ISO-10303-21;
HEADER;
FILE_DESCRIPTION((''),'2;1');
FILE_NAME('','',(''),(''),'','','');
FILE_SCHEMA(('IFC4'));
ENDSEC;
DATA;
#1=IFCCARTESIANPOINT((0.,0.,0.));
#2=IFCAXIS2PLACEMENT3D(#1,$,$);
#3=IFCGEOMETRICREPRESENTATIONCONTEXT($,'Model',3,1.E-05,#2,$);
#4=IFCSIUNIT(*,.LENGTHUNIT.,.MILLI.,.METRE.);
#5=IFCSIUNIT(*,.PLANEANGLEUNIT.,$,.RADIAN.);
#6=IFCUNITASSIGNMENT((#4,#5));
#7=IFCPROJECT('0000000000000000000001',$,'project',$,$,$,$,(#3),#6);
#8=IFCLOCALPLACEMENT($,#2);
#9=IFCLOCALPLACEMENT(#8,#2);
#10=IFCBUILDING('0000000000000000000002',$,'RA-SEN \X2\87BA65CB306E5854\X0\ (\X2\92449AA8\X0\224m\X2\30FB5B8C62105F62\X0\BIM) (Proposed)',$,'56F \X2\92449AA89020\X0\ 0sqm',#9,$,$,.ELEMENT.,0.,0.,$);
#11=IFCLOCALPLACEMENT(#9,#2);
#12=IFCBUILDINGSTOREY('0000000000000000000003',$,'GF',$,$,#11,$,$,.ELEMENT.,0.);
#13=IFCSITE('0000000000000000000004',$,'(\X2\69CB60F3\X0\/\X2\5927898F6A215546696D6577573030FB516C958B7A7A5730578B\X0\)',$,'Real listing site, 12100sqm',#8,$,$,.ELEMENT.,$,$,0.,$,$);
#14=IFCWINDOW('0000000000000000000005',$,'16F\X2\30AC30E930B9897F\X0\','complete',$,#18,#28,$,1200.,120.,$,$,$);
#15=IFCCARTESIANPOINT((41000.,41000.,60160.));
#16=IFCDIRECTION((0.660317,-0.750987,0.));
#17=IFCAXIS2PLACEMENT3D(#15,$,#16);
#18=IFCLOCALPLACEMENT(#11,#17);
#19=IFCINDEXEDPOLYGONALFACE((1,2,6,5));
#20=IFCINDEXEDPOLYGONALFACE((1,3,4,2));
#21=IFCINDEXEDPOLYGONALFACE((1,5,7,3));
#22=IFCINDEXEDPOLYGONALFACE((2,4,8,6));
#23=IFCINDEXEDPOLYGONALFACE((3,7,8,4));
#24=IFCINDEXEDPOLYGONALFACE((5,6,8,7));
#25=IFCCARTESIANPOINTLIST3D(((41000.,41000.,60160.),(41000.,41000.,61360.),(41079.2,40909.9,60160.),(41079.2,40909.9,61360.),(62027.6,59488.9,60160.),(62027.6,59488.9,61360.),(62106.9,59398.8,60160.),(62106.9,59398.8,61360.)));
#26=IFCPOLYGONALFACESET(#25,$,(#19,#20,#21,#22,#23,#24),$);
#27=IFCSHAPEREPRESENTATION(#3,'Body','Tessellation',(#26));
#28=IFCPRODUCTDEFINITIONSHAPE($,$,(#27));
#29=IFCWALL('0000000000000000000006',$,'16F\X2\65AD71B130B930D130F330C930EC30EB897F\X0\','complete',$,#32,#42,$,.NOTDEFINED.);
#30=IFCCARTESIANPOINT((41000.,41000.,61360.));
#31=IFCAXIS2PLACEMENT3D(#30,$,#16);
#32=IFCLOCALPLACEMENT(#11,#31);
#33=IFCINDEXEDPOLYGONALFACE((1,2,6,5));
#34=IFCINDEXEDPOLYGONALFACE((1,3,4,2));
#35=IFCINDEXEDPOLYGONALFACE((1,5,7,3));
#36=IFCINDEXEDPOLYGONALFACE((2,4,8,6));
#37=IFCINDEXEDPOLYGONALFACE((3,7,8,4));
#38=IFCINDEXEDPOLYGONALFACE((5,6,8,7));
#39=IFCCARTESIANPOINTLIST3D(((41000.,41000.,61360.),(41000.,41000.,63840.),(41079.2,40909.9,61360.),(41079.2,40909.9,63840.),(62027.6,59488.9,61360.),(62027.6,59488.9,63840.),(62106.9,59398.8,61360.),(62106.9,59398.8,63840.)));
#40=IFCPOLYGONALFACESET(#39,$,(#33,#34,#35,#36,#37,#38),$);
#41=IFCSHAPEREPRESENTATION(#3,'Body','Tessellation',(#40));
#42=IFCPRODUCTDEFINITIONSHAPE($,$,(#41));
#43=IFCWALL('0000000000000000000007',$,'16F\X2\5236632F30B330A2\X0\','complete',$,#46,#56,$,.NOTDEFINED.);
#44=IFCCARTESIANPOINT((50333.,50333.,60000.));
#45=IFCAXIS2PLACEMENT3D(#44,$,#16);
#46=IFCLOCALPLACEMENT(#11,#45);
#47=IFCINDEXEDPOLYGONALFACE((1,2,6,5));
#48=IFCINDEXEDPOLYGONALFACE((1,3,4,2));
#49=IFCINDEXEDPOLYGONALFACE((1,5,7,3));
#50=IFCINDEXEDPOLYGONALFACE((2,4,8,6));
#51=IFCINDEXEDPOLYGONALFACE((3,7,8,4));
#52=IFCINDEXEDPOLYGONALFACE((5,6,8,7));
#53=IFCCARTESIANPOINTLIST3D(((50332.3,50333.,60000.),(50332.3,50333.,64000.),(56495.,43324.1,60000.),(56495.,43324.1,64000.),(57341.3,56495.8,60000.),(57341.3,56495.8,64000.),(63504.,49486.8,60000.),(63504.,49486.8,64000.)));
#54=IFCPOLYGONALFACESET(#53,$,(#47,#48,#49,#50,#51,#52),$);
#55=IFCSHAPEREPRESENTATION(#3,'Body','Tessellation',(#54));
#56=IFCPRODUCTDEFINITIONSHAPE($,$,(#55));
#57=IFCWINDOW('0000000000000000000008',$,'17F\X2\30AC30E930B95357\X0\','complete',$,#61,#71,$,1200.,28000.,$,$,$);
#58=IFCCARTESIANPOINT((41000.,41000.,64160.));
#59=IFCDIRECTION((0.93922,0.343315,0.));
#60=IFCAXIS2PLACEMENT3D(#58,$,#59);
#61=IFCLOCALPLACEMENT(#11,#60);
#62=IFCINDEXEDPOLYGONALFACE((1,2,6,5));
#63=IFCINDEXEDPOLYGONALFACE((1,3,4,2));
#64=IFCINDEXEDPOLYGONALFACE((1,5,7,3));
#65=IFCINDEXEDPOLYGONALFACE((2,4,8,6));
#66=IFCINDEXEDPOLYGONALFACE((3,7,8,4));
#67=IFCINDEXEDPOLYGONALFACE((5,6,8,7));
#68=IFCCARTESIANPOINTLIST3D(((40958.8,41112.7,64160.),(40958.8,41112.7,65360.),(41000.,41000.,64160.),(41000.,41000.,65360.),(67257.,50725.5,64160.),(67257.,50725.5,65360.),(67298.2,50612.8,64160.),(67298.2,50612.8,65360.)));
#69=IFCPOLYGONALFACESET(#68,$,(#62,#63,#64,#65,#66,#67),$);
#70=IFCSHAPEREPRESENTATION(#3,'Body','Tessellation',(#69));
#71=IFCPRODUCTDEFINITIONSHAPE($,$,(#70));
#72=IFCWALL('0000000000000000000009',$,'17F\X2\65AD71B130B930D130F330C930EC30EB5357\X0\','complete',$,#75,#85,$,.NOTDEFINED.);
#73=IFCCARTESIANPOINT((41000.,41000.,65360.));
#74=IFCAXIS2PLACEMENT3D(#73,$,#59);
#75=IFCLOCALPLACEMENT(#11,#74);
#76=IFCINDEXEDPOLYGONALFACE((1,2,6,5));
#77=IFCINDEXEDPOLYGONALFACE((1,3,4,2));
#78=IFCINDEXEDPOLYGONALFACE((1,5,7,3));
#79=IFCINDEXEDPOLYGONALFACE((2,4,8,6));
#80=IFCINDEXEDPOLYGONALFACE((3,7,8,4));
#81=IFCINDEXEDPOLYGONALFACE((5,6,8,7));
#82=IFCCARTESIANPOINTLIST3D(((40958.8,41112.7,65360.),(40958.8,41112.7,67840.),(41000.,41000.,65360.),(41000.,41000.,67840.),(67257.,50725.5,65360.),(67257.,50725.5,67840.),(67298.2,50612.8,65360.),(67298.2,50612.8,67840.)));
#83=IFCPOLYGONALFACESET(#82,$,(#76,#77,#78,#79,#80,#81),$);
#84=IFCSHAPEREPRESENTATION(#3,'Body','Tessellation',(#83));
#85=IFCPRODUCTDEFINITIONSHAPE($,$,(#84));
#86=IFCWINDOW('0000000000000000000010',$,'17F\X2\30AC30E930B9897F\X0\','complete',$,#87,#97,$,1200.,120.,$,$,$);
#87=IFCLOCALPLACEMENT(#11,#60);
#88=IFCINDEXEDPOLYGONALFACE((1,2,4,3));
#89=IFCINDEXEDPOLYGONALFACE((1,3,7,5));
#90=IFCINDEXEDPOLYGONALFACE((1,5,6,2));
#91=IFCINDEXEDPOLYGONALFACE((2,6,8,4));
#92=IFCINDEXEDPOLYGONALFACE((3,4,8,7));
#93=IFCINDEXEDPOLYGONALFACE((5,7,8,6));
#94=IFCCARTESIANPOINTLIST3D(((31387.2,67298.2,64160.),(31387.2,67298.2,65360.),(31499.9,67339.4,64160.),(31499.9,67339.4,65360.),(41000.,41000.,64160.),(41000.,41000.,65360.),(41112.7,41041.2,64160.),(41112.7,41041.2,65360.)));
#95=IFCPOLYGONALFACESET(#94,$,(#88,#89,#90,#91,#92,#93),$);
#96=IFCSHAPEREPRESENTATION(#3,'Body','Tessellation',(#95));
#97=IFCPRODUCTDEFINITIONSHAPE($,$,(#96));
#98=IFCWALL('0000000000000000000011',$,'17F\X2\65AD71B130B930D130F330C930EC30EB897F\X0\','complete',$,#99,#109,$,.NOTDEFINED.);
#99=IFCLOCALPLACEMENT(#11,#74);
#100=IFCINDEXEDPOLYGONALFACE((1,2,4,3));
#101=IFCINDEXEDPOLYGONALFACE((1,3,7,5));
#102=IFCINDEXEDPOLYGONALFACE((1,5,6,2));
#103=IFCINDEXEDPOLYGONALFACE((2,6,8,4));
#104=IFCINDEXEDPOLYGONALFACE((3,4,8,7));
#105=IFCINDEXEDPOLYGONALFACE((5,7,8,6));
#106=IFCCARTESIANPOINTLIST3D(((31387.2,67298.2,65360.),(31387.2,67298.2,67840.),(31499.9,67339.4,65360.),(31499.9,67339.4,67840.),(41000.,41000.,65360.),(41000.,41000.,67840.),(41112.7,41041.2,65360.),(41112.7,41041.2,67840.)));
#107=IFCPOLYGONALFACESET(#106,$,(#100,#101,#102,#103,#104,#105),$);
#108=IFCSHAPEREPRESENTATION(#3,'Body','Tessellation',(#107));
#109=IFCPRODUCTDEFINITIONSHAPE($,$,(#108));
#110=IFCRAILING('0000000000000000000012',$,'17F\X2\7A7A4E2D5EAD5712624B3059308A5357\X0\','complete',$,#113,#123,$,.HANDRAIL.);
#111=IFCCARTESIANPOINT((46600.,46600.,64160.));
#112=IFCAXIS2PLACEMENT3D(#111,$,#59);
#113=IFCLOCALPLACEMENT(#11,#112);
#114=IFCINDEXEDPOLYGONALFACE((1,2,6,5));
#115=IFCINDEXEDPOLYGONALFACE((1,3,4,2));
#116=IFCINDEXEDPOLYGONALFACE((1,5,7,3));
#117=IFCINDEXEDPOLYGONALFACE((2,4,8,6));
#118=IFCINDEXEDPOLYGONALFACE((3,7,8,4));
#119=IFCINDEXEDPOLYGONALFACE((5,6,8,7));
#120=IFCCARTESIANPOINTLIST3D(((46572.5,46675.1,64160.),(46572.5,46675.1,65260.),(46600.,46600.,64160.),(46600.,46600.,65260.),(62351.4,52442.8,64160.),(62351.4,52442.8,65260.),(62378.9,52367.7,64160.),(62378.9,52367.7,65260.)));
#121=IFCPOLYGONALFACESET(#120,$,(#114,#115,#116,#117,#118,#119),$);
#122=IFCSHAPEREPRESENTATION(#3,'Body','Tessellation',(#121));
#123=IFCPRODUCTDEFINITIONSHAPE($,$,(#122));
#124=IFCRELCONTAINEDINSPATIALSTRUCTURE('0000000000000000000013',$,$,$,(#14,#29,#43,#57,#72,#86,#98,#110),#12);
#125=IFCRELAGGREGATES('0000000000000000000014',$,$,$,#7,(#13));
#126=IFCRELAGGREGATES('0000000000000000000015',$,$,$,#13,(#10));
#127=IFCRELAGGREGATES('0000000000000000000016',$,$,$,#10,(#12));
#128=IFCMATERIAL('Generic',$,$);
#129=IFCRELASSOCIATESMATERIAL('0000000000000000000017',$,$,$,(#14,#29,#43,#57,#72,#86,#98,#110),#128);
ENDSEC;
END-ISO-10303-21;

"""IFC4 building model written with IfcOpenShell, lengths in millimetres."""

from ifc_helpers import new_model, si_unit, frame, frame_2d, origin, place, context, project, spatial, rectangle, extrude, material, element, save


model = new_model("IFC4")

# Units and contexts
model_context = context("Model", 3, precision=1e-05, world=origin())
ifc_project = project(units=[si_unit("LENGTHUNIT", "METRE", prefix="MILLI"), si_unit("PLANEANGLEUNIT", "RADIAN")], contexts=[model_context])

# Site, building, storey
site_placement = place(None, origin())
site = spatial("IfcSite", under=ifc_project, at=site_placement, Name="(構想/大規模商業敷地・公開空地型)", ObjectType="Real listing site, 12100sqm", CompositionType="ELEMENT", RefElevation=0.0)
building_placement = place(site_placement, origin())
building = spatial("IfcBuilding", under=site, at=building_placement, Name="RA-SEN 螺旋の塔 (鉄骨224m・完成形BIM) (Proposed)", ObjectType="56F 鉄骨造 0sqm", CompositionType="ELEMENT", ElevationOfRefHeight=0.0, ElevationOfTerrain=0.0)
storey_placement = place(building_placement, origin())
storey = spatial("IfcBuildingStorey", under=building, at=storey_placement, Name="GF", CompositionType="ELEMENT", Elevation=0.0)

# Shared definitions
ifc_material = material(Name="Generic")

# Window
window_1_placement = place(storey_placement, frame((41000.0, 41000.0, 60160.0), x_axis=(0.660317, -0.750987, 0.0)))
element("IfcWindow", 1, at=window_1_placement, inside=storey, material=ifc_material, Name="16Fガラス西", Description="complete", OverallHeight=1200.0, OverallWidth=120.0, context=model_context, shape_type="SweptSolid", body=[
    extrude(rectangle(XDim=120.0, YDim=28000.0, at=frame_2d((60.0, 14000.0))), frame((41000.0, 41000.0, 60160.0), x_axis=(0.660317, -0.750987, 0.0)), (0.0, 0.0, 1.0), 1200.0),
])

# Walls
wall_1_placement = place(storey_placement, frame((41000.0, 41000.0, 61360.0), x_axis=(0.660317, -0.750987, 0.0)))
element("IfcWall", 2, at=wall_1_placement, inside=storey, material=ifc_material, Name="16F断熱スパンドレル西", Description="complete", PredefinedType="NOTDEFINED", context=model_context, shape_type="SweptSolid", body=[
    extrude(rectangle(XDim=120.0, YDim=28000.0, at=frame_2d((60.0, 14000.0))), frame((41000.0, 41000.0, 61360.0), x_axis=(0.660317, -0.750987, 0.0)), (0.0, 0.0, 1.0), 2480.0),
])
wall_2_placement = place(storey_placement, frame((50333.0, 50333.0, 60000.0), x_axis=(0.660317, -0.750987, 0.0)))
element("IfcWall", 3, at=wall_2_placement, inside=storey, material=ifc_material, Name="16F制振コア", Description="complete", PredefinedType="NOTDEFINED", context=model_context, shape_type="SweptSolid", body=[
    extrude(rectangle(XDim=9333.0, YDim=9333.0, at=frame_2d((4666.0, 4666.0))), frame((50333.0, 50333.0, 60000.0), x_axis=(0.660317, -0.750987, 0.0)), (0.0, 0.0, 1.0), 4000.0),
])

# Window
window_2_placement = place(storey_placement, frame((41000.0, 41000.0, 64160.0), x_axis=(0.93922, 0.343315, 0.0)))
element("IfcWindow", 4, at=window_2_placement, inside=storey, material=ifc_material, Name="17Fガラス南", Description="complete", OverallHeight=1200.0, OverallWidth=28000.0, context=model_context, shape_type="SweptSolid", body=[
    extrude(rectangle(XDim=28000.0, YDim=120.0, at=frame_2d((14000.0, 60.0))), frame((41000.0, 41000.0, 64160.0), x_axis=(0.93922, 0.343315, 0.0)), (0.0, 0.0, 1.0), 1200.0),
])

# Wall
wall_3_placement = place(storey_placement, frame((41000.0, 41000.0, 65360.0), x_axis=(0.93922, 0.343315, 0.0)))
element("IfcWall", 5, at=wall_3_placement, inside=storey, material=ifc_material, Name="17F断熱スパンドレル南", Description="complete", PredefinedType="NOTDEFINED", context=model_context, shape_type="SweptSolid", body=[
    extrude(rectangle(XDim=28000.0, YDim=120.0, at=frame_2d((14000.0, 60.0))), frame((41000.0, 41000.0, 65360.0), x_axis=(0.93922, 0.343315, 0.0)), (0.0, 0.0, 1.0), 2480.0),
])

# Window
window_3_placement = place(storey_placement, frame((41000.0, 41000.0, 64160.0), x_axis=(0.93922, 0.343315, 0.0)))
element("IfcWindow", 6, at=window_3_placement, inside=storey, material=ifc_material, Name="17Fガラス西", Description="complete", OverallHeight=1200.0, OverallWidth=120.0, context=model_context, shape_type="SweptSolid", body=[
    extrude(rectangle(XDim=120.0, YDim=28000.0, at=frame_2d((60.0, 14000.0))), frame((41000.0, 41000.0, 64160.0), x_axis=(0.93922, 0.343315, 0.0)), (0.0, 0.0, 1.0), 1200.0),
])

# Wall
wall_4_placement = place(storey_placement, frame((41000.0, 41000.0, 65360.0), x_axis=(0.93922, 0.343315, 0.0)))
element("IfcWall", 7, at=wall_4_placement, inside=storey, material=ifc_material, Name="17F断熱スパンドレル西", Description="complete", PredefinedType="NOTDEFINED", context=model_context, shape_type="SweptSolid", body=[
    extrude(rectangle(XDim=120.0, YDim=28000.0, at=frame_2d((60.0, 14000.0))), frame((41000.0, 41000.0, 65360.0), x_axis=(0.93922, 0.343315, 0.0)), (0.0, 0.0, 1.0), 2480.0),
])

# Railing
railing_placement = place(storey_placement, frame((46600.0, 46600.0, 64160.0), x_axis=(0.93922, 0.343315, 0.0)))
element("IfcRailing", 8, at=railing_placement, inside=storey, material=ifc_material, Name="17F空中庭園手すり南", Description="complete", PredefinedType="HANDRAIL", context=model_context, shape_type="SweptSolid", body=[
    extrude(rectangle(XDim=16800.0, YDim=80.0, at=frame_2d((8400.0, 40.0))), frame((46600.0, 46600.0, 64160.0), x_axis=(0.93922, 0.343315, 0.0)), (0.0, 0.0, 1.0), 1100.0),
])

save(model, "model.ifc")
